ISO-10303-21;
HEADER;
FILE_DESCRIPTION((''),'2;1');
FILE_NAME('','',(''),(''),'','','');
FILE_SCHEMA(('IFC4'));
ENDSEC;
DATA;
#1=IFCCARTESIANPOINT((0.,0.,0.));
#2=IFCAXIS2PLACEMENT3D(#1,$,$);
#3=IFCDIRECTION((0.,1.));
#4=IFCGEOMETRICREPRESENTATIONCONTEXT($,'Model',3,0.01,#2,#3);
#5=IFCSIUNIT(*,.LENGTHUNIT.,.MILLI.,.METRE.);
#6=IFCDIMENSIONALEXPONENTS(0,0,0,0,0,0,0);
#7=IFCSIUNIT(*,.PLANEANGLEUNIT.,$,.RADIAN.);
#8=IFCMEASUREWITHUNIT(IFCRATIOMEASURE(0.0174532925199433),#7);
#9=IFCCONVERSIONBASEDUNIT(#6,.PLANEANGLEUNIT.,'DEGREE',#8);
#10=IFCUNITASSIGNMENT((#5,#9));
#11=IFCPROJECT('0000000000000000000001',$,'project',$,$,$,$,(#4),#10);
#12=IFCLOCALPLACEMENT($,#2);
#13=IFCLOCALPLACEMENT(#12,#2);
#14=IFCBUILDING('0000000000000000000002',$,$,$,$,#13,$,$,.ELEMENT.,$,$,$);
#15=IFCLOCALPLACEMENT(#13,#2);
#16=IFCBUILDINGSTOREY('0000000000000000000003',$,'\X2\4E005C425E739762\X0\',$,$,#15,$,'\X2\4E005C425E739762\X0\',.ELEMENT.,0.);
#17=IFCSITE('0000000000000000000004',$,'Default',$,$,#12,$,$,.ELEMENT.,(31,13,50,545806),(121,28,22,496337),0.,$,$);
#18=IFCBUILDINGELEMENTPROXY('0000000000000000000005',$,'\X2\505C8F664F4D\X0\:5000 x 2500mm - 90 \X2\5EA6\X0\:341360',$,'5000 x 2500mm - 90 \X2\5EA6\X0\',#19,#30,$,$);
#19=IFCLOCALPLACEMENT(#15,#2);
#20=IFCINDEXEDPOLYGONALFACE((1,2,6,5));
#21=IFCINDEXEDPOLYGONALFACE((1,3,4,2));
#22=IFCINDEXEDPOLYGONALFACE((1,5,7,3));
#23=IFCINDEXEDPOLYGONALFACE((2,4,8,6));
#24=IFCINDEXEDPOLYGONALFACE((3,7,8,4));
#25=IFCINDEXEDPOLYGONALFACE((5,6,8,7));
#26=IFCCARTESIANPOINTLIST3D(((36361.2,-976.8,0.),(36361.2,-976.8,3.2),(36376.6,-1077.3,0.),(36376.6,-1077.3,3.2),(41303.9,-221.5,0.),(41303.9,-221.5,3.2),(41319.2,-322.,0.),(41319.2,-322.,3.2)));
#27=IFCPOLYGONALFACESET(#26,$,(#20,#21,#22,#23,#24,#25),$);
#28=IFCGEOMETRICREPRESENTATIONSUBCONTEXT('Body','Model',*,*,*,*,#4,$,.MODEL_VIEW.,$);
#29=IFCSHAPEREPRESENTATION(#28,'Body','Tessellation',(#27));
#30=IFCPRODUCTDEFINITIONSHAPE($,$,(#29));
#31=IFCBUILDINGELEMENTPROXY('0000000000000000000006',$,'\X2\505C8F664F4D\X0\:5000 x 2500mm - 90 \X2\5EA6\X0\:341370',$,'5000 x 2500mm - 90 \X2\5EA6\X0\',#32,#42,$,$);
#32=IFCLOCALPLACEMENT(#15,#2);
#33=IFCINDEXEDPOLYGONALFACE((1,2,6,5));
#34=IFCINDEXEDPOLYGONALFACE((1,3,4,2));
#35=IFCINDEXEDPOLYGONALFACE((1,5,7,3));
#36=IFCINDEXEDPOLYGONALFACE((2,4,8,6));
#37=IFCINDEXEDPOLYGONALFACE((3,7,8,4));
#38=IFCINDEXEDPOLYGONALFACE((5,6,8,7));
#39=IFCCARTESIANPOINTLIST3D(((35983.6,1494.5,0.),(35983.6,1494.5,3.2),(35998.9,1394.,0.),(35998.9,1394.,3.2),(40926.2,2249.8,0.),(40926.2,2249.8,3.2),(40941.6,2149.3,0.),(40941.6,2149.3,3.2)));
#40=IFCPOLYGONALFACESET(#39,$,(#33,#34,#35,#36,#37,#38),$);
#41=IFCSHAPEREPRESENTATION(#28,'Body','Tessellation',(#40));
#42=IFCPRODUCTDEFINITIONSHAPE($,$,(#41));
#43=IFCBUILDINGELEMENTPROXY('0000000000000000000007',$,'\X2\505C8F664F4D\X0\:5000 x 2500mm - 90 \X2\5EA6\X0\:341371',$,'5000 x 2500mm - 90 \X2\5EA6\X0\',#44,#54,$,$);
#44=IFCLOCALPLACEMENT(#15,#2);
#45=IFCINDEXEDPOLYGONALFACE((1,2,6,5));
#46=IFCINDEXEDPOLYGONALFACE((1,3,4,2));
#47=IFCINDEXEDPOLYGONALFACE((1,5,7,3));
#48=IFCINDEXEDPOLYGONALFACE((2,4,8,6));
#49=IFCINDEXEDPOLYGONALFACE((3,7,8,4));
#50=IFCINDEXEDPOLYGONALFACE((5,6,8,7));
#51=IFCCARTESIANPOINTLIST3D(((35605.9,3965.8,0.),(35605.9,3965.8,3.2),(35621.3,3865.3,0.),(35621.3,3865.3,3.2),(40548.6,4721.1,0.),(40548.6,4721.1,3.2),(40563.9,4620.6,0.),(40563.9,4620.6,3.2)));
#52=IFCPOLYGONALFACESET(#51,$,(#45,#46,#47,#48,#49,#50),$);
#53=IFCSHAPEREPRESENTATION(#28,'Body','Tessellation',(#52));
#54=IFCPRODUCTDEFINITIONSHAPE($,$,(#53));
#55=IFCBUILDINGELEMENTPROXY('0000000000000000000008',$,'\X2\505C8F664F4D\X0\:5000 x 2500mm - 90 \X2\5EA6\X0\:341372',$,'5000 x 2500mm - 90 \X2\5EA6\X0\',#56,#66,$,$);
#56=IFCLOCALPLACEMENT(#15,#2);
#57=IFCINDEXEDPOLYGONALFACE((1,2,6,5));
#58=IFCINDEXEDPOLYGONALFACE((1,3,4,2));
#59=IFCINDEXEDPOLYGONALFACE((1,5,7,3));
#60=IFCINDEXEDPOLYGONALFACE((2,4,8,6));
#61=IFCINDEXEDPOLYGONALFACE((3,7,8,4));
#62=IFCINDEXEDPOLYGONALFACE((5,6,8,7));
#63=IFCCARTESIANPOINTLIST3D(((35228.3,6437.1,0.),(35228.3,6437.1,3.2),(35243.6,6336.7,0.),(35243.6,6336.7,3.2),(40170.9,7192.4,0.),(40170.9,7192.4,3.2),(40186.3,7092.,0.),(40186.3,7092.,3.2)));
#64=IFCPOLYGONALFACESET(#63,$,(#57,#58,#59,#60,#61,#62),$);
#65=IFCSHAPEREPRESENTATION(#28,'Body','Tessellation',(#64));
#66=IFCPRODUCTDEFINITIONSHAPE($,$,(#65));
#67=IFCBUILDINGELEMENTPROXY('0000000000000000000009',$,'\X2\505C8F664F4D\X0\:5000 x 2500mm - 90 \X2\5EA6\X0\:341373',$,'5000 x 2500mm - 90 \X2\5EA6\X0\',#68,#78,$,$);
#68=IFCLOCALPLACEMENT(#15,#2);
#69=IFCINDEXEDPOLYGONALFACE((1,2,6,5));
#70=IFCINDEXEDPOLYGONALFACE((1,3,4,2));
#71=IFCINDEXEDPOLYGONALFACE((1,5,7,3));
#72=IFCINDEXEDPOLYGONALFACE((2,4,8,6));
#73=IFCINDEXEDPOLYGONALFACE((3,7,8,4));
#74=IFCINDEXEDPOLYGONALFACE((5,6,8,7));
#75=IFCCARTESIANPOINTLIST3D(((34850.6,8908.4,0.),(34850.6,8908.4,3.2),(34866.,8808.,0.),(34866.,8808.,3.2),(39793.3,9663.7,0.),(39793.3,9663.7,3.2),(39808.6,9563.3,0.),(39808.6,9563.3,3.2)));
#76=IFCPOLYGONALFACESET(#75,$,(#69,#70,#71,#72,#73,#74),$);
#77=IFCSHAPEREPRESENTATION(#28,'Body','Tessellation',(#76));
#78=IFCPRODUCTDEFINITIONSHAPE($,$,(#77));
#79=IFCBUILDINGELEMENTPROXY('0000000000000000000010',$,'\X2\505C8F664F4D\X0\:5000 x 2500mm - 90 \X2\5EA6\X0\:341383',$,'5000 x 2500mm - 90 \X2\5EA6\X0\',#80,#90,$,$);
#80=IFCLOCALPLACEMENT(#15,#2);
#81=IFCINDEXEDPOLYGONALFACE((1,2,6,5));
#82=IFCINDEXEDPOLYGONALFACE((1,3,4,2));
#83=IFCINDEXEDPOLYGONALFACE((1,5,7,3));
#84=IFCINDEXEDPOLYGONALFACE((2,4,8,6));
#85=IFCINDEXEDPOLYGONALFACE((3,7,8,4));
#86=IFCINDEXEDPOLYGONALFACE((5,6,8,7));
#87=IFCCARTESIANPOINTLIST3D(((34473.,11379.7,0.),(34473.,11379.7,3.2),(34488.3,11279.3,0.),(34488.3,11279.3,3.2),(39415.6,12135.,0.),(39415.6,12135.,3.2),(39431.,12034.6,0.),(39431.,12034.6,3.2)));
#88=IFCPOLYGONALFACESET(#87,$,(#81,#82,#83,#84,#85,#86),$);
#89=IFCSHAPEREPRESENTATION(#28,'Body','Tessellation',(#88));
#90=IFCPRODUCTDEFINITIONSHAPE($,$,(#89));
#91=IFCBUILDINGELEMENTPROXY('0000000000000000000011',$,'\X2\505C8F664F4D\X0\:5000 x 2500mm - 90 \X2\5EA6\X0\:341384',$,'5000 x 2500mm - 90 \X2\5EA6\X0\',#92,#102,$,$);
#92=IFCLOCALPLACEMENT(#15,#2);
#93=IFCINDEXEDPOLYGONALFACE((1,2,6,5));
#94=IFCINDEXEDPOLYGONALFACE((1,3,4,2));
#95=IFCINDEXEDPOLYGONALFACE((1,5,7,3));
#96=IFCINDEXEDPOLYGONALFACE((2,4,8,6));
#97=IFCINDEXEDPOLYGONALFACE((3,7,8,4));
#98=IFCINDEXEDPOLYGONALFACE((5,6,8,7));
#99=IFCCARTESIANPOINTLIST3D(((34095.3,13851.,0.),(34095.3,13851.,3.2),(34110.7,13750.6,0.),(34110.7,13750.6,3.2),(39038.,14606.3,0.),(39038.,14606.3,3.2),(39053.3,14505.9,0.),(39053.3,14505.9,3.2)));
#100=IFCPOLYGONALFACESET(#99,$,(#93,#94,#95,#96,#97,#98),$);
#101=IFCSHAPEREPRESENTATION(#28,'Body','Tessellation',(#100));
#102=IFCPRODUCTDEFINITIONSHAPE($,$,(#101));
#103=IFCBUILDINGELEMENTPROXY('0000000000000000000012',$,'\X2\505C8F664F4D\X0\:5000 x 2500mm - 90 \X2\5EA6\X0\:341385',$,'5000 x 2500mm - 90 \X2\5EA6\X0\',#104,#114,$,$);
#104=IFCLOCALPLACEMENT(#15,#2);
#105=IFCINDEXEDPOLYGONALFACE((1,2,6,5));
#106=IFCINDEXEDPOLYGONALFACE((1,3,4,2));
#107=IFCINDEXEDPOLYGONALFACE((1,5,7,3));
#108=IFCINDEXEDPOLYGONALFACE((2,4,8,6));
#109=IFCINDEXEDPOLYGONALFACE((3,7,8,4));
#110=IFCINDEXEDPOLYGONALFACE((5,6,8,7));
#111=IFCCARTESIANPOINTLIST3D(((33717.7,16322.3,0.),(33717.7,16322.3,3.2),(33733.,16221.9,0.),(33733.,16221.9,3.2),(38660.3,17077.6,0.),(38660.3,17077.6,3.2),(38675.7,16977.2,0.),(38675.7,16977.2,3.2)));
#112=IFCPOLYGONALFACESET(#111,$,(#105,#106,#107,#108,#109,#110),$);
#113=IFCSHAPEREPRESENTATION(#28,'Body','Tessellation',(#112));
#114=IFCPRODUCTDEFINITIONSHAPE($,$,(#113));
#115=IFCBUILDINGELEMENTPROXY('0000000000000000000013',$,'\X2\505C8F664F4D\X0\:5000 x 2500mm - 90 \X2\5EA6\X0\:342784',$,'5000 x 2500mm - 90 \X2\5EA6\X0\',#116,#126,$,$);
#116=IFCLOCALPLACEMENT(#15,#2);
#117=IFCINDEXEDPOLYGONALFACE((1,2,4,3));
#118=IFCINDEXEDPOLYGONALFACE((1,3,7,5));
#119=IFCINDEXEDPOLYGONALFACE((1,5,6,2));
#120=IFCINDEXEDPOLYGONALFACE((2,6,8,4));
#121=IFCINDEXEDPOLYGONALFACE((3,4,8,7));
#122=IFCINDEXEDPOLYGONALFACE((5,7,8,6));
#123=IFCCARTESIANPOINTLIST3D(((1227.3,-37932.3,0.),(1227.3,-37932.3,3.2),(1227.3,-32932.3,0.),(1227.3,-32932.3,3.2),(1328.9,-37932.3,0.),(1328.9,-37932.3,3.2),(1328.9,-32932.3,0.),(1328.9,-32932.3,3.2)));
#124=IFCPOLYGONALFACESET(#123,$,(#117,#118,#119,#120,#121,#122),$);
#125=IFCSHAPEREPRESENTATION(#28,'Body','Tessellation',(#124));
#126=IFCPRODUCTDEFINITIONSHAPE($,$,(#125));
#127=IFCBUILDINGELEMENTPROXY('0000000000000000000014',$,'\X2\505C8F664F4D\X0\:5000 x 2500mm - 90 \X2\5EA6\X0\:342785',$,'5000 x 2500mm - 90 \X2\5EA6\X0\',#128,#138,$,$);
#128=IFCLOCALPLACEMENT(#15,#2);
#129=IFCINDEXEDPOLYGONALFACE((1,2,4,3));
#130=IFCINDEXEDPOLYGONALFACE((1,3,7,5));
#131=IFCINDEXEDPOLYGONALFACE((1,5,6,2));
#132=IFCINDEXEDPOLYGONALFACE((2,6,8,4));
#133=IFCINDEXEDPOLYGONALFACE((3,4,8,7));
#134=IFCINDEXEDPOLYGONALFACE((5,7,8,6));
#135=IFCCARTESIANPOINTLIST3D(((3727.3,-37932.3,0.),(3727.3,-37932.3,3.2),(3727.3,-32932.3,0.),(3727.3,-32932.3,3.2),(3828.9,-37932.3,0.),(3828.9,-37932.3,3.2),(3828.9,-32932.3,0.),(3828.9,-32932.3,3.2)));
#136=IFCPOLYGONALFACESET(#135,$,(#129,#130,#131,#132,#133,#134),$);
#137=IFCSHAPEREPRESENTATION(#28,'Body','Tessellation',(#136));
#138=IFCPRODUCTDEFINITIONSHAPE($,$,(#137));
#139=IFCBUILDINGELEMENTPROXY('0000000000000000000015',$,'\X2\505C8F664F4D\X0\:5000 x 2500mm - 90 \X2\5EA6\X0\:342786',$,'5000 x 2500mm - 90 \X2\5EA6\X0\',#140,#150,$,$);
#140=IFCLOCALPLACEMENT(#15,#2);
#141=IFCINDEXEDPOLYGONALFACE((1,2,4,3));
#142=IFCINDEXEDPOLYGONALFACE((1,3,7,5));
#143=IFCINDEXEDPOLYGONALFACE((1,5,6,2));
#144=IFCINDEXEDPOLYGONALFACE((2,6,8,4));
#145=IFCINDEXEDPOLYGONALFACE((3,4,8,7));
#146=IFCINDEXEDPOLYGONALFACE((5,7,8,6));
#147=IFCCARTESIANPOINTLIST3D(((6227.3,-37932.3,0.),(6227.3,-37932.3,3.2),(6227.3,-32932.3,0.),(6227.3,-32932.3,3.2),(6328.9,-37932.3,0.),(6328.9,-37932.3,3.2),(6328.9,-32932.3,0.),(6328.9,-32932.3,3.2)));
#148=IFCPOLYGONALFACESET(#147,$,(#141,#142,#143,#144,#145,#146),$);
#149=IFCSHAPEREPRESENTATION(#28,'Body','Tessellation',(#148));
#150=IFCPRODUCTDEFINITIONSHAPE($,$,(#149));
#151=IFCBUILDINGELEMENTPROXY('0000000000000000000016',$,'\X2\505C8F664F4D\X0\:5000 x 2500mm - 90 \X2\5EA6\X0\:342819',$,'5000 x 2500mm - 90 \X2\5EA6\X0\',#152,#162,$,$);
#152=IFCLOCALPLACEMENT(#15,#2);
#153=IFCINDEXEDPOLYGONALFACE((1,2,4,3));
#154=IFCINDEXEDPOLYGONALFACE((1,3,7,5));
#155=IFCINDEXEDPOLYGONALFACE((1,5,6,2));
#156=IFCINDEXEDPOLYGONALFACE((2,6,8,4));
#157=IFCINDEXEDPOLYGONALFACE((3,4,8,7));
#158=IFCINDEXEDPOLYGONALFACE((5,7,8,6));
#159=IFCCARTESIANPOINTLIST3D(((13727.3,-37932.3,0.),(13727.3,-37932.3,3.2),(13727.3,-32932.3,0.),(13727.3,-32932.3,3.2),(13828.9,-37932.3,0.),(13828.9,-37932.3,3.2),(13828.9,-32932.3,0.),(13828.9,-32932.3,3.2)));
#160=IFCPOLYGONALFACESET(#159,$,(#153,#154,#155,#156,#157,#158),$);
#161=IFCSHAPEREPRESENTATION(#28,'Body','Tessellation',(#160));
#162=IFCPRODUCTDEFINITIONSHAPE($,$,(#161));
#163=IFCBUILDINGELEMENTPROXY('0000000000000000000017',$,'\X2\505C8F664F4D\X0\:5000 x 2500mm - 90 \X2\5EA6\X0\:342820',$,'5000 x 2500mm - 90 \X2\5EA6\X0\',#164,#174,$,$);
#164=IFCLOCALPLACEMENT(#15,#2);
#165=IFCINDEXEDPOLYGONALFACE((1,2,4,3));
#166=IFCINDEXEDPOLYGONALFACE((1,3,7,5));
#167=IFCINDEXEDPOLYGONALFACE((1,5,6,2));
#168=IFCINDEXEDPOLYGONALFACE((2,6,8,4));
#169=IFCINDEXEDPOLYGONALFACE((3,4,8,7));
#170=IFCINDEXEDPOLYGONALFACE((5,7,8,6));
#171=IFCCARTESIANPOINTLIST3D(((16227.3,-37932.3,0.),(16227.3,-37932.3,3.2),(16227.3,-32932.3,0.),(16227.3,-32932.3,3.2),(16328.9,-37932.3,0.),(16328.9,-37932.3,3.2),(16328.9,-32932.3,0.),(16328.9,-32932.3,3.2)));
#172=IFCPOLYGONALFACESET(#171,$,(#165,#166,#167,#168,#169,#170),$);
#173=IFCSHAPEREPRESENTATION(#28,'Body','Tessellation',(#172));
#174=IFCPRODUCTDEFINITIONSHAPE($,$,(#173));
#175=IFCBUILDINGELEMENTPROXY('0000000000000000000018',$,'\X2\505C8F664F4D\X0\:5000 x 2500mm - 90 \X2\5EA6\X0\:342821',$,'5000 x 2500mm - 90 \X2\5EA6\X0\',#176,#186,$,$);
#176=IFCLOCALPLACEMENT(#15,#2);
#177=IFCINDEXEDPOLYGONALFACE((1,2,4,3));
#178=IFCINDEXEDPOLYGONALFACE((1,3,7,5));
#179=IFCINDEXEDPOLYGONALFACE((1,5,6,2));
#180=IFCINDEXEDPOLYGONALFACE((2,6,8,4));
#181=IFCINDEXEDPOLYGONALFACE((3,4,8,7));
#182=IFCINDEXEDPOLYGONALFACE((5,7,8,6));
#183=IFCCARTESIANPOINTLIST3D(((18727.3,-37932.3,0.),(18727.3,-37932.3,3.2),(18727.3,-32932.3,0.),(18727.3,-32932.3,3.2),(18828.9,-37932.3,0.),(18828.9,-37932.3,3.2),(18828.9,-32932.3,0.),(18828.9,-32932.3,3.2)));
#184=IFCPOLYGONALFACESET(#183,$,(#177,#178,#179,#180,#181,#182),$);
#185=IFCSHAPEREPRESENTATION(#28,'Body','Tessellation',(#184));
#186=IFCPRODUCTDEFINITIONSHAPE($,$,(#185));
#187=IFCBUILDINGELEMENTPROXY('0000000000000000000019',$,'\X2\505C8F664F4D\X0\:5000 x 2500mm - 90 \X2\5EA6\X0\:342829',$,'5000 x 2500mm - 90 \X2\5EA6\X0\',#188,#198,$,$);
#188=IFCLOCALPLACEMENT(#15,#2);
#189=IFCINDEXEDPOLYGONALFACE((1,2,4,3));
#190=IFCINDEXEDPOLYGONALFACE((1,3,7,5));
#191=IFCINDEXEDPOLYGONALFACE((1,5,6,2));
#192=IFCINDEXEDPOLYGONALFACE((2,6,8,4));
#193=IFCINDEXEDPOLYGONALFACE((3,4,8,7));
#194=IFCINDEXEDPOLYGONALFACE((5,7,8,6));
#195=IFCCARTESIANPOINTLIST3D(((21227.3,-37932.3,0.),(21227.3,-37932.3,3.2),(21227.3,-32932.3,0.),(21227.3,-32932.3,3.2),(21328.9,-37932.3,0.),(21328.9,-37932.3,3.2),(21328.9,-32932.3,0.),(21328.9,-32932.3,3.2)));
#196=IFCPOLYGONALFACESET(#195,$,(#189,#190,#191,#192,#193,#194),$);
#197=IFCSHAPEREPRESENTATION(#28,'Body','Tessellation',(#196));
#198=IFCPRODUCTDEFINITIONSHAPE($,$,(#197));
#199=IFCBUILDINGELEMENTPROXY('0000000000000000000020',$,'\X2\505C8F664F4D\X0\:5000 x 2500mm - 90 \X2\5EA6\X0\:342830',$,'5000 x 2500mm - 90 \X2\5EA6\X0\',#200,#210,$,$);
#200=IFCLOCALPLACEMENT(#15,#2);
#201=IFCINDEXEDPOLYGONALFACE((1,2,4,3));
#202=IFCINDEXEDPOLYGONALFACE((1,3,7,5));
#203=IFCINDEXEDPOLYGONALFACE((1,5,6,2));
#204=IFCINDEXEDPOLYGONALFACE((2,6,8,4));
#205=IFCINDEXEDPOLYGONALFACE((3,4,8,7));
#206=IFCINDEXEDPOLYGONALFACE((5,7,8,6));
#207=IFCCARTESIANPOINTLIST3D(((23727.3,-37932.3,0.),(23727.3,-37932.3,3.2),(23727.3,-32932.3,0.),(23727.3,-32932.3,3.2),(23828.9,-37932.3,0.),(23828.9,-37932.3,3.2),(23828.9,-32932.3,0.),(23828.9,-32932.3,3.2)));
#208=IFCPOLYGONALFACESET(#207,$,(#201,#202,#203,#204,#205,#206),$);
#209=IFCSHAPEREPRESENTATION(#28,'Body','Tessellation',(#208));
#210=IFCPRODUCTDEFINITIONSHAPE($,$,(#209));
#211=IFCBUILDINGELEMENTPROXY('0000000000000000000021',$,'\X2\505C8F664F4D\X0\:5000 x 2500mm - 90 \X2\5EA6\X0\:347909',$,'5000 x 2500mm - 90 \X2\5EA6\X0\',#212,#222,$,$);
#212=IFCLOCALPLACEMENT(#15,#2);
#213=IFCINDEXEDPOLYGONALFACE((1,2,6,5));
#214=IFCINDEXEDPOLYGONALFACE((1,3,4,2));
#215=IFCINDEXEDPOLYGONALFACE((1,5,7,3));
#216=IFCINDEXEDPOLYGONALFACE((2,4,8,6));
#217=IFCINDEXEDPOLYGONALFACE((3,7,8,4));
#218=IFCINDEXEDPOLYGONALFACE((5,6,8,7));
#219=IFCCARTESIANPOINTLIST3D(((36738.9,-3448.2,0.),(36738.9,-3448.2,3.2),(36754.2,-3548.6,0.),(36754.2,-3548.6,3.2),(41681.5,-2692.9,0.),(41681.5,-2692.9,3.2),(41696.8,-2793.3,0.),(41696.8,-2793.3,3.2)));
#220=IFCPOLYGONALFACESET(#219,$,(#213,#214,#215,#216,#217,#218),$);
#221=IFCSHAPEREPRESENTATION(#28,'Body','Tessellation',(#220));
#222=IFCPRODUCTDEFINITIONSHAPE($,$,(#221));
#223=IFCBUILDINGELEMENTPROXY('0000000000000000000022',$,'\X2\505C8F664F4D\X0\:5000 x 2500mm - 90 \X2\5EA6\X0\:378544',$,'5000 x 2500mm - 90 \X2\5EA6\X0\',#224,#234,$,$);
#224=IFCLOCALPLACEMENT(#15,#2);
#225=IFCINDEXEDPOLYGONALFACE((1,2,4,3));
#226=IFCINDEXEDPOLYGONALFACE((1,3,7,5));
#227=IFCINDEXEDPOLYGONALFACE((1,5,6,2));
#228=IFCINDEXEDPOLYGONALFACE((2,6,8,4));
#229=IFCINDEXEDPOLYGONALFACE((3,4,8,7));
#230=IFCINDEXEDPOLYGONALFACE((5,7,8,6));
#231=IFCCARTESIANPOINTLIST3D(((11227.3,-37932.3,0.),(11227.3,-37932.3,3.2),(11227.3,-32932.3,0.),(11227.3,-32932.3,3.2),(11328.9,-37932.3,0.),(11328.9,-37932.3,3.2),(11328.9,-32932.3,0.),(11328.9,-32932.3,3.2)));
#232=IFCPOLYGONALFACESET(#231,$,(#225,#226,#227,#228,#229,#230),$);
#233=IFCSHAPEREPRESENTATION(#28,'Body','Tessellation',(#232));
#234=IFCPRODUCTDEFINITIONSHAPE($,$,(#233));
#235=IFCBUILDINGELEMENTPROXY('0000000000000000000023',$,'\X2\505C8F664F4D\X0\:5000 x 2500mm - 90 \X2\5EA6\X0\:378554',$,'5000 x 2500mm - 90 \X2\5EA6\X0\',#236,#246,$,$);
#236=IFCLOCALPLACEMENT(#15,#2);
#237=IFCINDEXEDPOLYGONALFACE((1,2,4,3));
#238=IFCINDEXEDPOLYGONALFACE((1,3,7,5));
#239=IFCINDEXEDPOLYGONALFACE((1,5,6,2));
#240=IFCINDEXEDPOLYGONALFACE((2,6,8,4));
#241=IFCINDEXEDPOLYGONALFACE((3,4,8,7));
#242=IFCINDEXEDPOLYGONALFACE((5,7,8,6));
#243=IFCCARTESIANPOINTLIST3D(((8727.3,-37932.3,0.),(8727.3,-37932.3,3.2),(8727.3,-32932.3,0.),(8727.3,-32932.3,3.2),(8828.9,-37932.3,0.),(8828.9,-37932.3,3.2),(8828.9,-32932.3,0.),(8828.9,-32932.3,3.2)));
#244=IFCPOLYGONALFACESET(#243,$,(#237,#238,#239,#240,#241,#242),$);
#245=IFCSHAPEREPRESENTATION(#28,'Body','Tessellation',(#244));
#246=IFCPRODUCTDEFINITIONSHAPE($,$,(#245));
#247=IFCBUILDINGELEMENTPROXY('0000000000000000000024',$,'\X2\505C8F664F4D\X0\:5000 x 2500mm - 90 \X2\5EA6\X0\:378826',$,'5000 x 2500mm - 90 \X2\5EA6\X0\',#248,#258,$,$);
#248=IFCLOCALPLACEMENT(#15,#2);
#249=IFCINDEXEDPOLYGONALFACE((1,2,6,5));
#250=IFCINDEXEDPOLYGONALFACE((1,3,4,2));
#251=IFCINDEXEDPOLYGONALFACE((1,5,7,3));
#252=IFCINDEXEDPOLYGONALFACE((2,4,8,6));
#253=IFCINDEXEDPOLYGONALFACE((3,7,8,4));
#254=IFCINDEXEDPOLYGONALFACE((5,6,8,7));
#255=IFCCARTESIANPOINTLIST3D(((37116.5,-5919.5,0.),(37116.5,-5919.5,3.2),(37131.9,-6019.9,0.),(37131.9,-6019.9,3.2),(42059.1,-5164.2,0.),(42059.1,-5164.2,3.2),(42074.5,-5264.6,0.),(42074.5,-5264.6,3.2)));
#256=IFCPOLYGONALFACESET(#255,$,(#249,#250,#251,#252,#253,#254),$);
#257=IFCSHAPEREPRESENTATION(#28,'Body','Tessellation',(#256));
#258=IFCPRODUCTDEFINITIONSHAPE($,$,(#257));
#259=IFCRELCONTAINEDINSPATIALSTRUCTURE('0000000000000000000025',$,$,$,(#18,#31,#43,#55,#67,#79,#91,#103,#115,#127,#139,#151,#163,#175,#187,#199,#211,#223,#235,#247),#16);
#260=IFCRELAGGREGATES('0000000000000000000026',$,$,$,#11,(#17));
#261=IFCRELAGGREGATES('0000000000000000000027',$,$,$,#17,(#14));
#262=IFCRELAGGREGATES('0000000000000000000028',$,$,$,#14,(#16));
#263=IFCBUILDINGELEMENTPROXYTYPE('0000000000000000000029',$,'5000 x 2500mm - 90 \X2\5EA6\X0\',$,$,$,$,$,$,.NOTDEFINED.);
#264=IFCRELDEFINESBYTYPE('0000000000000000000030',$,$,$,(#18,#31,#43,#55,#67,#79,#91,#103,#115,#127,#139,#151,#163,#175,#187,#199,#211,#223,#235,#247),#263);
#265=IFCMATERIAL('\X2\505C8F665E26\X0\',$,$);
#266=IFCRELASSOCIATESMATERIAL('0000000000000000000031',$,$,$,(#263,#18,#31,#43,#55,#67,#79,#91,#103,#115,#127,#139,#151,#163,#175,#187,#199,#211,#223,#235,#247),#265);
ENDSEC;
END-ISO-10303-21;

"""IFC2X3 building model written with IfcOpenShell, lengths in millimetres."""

from ifc_helpers import new_model, entity, si_unit, converted_unit, direction, frame, origin, origin_2d_with_axis, place, context, subcontext, project, spatial, rectangle, extrude, source, transform, mapped, material, type_object, type_shapes, element, save


model = new_model("IFC2X3")

# Units and contexts
model_context = context("Model", 3, precision=0.01, world=origin(), true_north=direction((0.0, 1.0)))
body_context = subcontext(model_context, "Body", "Model", "MODEL_VIEW")
ifc_project = project(units=[si_unit("LENGTHUNIT", "METRE", prefix="MILLI"), converted_unit("PLANEANGLEUNIT", "DEGREE", entity("IfcRatioMeasure", 0.0174532925199433), si_unit("PLANEANGLEUNIT", "RADIAN"), dimensions=[0, 0, 0, 0, 0, 0, 0])], contexts=[model_context])

# Site, building, storey
site_placement = place(None, origin())
site = spatial("IfcSite", under=ifc_project, at=site_placement, Name="Default", CompositionType="ELEMENT", RefLatitude=(31, 13, 50, 545806), RefLongitude=(121, 28, 22, 496337), RefElevation=0.0)
building_placement = place(site_placement, origin())
building = spatial("IfcBuilding", under=site, at=building_placement, CompositionType="ELEMENT")
storey_placement = place(building_placement, origin())
storey = spatial("IfcBuildingStorey", under=building, at=storey_placement, Name="一层平面", LongName="一层平面", CompositionType="ELEMENT", Elevation=0.0)

# Building element proxies
ifc_material_1 = material(Name="停车带")
building_element_proxy_type = type_object("IfcBuildingElementProxyType", Name="5000 x 2500mm - 90 度", PredefinedType="NOTDEFINED", material=ifc_material_1)
shared_shape = source(origin(), body_context, "Body", "SweptSolid", [
    extrude(rectangle(XDim=101.6, YDim=5000.0, at=origin_2d_with_axis()), frame((0.0, 2500.0, 0.0)), (0.0, 0.0, 1.0), 3.2),
])
type_shapes(building_element_proxy_type, [shared_shape])
for number, where, z_axis, x_axis, name in (
    (1, (36368.9, -1027.1, 0.0), (0.0, 0.0, 1.0), (0.151059, -0.988525, 0.0), "停车位:5000 x 2500mm - 90 度:341360"),
    (2, (35991.3, 1444.3, 0.0), (0.0, 0.0, 1.0), (0.151059, -0.988525, 0.0), "停车位:5000 x 2500mm - 90 度:341370"),
    (3, (35613.6, 3915.6, 0.0), (0.0, 0.0, 1.0), (0.151059, -0.988525, 0.0), "停车位:5000 x 2500mm - 90 度:341371"),
    (4, (35236.0, 6386.9, 0.0), (0.0, 0.0, 1.0), (0.151059, -0.988525, 0.0), "停车位:5000 x 2500mm - 90 度:341372"),
    (5, (34858.3, 8858.2, 0.0), (0.0, 0.0, 1.0), (0.151059, -0.988525, 0.0), "停车位:5000 x 2500mm - 90 度:341373"),
    (6, (34480.7, 11329.5, 0.0), (0.0, 0.0, 1.0), (0.151059, -0.988525, 0.0), "停车位:5000 x 2500mm - 90 度:341383"),
    (7, (34103.0, 13800.8, 0.0), (0.0, 0.0, 1.0), (0.151059, -0.988525, 0.0), "停车位:5000 x 2500mm - 90 度:341384"),
    (8, (33725.4, 16272.1, 0.0), (0.0, 0.0, 1.0), (0.151059, -0.988525, 0.0), "停车位:5000 x 2500mm - 90 度:341385"),
    (9, (1278.1, -32932.3, 0.0), (0.0, 0.0, 1.0), (-1.0, 0.0, 0.0), "停车位:5000 x 2500mm - 90 度:342784"),
    (10, (3778.1, -32932.3, 0.0), (0.0, 0.0, 1.0), (-1.0, 0.0, 0.0), "停车位:5000 x 2500mm - 90 度:342785"),
    (11, (6278.1, -32932.3, 0.0), (0.0, 0.0, 1.0), (-1.0, 0.0, 0.0), "停车位:5000 x 2500mm - 90 度:342786"),
    (12, (13778.1, -32932.3, 0.0), (0.0, 0.0, 1.0), (-1.0, 0.0, 0.0), "停车位:5000 x 2500mm - 90 度:342819"),
    (13, (16278.1, -32932.3, 0.0), (0.0, 0.0, 1.0), (-1.0, 0.0, 0.0), "停车位:5000 x 2500mm - 90 度:342820"),
    (14, (18778.1, -32932.3, 0.0), (0.0, 0.0, 1.0), (-1.0, 0.0, 0.0), "停车位:5000 x 2500mm - 90 度:342821"),
    (15, (21278.1, -32932.3, 0.0), (0.0, 0.0, 1.0), (-1.0, 0.0, 0.0), "停车位:5000 x 2500mm - 90 度:342829"),
    (16, (23778.1, -32932.3, 0.0), (0.0, 0.0, 1.0), (-1.0, 0.0, 0.0), "停车位:5000 x 2500mm - 90 度:342830"),
    (17, (36746.6, -3498.4, 0.0), (0.0, 0.0, 1.0), (0.151059, -0.988525, 0.0), "停车位:5000 x 2500mm - 90 度:347909"),
    (18, (11278.1, -32932.3, 0.0), (0.0, 0.0, 1.0), (-1.0, 0.0, 0.0), "停车位:5000 x 2500mm - 90 度:378544"),
    (19, (8778.1, -32932.3, 0.0), (0.0, 0.0, 1.0), (-1.0, 0.0, 0.0), "停车位:5000 x 2500mm - 90 度:378554"),
    (20, (37124.2, -5969.7, 0.0), (0.0, 0.0, 1.0), (0.151059, -0.988525, 0.0), "停车位:5000 x 2500mm - 90 度:378826"),
):
    element("IfcBuildingElementProxy", number, at=place(storey_placement, frame(where, z_axis=z_axis, x_axis=x_axis)), inside=storey, type_object=building_element_proxy_type, material=ifc_material_1, Name=name, ObjectType="5000 x 2500mm - 90 度", context=body_context, shape_type="MappedRepresentation", body=[
        mapped(shared_shape, transform((0.0, 0.0, 0.0), scale=1.0)),
    ])

save(model, "model.ifc")
